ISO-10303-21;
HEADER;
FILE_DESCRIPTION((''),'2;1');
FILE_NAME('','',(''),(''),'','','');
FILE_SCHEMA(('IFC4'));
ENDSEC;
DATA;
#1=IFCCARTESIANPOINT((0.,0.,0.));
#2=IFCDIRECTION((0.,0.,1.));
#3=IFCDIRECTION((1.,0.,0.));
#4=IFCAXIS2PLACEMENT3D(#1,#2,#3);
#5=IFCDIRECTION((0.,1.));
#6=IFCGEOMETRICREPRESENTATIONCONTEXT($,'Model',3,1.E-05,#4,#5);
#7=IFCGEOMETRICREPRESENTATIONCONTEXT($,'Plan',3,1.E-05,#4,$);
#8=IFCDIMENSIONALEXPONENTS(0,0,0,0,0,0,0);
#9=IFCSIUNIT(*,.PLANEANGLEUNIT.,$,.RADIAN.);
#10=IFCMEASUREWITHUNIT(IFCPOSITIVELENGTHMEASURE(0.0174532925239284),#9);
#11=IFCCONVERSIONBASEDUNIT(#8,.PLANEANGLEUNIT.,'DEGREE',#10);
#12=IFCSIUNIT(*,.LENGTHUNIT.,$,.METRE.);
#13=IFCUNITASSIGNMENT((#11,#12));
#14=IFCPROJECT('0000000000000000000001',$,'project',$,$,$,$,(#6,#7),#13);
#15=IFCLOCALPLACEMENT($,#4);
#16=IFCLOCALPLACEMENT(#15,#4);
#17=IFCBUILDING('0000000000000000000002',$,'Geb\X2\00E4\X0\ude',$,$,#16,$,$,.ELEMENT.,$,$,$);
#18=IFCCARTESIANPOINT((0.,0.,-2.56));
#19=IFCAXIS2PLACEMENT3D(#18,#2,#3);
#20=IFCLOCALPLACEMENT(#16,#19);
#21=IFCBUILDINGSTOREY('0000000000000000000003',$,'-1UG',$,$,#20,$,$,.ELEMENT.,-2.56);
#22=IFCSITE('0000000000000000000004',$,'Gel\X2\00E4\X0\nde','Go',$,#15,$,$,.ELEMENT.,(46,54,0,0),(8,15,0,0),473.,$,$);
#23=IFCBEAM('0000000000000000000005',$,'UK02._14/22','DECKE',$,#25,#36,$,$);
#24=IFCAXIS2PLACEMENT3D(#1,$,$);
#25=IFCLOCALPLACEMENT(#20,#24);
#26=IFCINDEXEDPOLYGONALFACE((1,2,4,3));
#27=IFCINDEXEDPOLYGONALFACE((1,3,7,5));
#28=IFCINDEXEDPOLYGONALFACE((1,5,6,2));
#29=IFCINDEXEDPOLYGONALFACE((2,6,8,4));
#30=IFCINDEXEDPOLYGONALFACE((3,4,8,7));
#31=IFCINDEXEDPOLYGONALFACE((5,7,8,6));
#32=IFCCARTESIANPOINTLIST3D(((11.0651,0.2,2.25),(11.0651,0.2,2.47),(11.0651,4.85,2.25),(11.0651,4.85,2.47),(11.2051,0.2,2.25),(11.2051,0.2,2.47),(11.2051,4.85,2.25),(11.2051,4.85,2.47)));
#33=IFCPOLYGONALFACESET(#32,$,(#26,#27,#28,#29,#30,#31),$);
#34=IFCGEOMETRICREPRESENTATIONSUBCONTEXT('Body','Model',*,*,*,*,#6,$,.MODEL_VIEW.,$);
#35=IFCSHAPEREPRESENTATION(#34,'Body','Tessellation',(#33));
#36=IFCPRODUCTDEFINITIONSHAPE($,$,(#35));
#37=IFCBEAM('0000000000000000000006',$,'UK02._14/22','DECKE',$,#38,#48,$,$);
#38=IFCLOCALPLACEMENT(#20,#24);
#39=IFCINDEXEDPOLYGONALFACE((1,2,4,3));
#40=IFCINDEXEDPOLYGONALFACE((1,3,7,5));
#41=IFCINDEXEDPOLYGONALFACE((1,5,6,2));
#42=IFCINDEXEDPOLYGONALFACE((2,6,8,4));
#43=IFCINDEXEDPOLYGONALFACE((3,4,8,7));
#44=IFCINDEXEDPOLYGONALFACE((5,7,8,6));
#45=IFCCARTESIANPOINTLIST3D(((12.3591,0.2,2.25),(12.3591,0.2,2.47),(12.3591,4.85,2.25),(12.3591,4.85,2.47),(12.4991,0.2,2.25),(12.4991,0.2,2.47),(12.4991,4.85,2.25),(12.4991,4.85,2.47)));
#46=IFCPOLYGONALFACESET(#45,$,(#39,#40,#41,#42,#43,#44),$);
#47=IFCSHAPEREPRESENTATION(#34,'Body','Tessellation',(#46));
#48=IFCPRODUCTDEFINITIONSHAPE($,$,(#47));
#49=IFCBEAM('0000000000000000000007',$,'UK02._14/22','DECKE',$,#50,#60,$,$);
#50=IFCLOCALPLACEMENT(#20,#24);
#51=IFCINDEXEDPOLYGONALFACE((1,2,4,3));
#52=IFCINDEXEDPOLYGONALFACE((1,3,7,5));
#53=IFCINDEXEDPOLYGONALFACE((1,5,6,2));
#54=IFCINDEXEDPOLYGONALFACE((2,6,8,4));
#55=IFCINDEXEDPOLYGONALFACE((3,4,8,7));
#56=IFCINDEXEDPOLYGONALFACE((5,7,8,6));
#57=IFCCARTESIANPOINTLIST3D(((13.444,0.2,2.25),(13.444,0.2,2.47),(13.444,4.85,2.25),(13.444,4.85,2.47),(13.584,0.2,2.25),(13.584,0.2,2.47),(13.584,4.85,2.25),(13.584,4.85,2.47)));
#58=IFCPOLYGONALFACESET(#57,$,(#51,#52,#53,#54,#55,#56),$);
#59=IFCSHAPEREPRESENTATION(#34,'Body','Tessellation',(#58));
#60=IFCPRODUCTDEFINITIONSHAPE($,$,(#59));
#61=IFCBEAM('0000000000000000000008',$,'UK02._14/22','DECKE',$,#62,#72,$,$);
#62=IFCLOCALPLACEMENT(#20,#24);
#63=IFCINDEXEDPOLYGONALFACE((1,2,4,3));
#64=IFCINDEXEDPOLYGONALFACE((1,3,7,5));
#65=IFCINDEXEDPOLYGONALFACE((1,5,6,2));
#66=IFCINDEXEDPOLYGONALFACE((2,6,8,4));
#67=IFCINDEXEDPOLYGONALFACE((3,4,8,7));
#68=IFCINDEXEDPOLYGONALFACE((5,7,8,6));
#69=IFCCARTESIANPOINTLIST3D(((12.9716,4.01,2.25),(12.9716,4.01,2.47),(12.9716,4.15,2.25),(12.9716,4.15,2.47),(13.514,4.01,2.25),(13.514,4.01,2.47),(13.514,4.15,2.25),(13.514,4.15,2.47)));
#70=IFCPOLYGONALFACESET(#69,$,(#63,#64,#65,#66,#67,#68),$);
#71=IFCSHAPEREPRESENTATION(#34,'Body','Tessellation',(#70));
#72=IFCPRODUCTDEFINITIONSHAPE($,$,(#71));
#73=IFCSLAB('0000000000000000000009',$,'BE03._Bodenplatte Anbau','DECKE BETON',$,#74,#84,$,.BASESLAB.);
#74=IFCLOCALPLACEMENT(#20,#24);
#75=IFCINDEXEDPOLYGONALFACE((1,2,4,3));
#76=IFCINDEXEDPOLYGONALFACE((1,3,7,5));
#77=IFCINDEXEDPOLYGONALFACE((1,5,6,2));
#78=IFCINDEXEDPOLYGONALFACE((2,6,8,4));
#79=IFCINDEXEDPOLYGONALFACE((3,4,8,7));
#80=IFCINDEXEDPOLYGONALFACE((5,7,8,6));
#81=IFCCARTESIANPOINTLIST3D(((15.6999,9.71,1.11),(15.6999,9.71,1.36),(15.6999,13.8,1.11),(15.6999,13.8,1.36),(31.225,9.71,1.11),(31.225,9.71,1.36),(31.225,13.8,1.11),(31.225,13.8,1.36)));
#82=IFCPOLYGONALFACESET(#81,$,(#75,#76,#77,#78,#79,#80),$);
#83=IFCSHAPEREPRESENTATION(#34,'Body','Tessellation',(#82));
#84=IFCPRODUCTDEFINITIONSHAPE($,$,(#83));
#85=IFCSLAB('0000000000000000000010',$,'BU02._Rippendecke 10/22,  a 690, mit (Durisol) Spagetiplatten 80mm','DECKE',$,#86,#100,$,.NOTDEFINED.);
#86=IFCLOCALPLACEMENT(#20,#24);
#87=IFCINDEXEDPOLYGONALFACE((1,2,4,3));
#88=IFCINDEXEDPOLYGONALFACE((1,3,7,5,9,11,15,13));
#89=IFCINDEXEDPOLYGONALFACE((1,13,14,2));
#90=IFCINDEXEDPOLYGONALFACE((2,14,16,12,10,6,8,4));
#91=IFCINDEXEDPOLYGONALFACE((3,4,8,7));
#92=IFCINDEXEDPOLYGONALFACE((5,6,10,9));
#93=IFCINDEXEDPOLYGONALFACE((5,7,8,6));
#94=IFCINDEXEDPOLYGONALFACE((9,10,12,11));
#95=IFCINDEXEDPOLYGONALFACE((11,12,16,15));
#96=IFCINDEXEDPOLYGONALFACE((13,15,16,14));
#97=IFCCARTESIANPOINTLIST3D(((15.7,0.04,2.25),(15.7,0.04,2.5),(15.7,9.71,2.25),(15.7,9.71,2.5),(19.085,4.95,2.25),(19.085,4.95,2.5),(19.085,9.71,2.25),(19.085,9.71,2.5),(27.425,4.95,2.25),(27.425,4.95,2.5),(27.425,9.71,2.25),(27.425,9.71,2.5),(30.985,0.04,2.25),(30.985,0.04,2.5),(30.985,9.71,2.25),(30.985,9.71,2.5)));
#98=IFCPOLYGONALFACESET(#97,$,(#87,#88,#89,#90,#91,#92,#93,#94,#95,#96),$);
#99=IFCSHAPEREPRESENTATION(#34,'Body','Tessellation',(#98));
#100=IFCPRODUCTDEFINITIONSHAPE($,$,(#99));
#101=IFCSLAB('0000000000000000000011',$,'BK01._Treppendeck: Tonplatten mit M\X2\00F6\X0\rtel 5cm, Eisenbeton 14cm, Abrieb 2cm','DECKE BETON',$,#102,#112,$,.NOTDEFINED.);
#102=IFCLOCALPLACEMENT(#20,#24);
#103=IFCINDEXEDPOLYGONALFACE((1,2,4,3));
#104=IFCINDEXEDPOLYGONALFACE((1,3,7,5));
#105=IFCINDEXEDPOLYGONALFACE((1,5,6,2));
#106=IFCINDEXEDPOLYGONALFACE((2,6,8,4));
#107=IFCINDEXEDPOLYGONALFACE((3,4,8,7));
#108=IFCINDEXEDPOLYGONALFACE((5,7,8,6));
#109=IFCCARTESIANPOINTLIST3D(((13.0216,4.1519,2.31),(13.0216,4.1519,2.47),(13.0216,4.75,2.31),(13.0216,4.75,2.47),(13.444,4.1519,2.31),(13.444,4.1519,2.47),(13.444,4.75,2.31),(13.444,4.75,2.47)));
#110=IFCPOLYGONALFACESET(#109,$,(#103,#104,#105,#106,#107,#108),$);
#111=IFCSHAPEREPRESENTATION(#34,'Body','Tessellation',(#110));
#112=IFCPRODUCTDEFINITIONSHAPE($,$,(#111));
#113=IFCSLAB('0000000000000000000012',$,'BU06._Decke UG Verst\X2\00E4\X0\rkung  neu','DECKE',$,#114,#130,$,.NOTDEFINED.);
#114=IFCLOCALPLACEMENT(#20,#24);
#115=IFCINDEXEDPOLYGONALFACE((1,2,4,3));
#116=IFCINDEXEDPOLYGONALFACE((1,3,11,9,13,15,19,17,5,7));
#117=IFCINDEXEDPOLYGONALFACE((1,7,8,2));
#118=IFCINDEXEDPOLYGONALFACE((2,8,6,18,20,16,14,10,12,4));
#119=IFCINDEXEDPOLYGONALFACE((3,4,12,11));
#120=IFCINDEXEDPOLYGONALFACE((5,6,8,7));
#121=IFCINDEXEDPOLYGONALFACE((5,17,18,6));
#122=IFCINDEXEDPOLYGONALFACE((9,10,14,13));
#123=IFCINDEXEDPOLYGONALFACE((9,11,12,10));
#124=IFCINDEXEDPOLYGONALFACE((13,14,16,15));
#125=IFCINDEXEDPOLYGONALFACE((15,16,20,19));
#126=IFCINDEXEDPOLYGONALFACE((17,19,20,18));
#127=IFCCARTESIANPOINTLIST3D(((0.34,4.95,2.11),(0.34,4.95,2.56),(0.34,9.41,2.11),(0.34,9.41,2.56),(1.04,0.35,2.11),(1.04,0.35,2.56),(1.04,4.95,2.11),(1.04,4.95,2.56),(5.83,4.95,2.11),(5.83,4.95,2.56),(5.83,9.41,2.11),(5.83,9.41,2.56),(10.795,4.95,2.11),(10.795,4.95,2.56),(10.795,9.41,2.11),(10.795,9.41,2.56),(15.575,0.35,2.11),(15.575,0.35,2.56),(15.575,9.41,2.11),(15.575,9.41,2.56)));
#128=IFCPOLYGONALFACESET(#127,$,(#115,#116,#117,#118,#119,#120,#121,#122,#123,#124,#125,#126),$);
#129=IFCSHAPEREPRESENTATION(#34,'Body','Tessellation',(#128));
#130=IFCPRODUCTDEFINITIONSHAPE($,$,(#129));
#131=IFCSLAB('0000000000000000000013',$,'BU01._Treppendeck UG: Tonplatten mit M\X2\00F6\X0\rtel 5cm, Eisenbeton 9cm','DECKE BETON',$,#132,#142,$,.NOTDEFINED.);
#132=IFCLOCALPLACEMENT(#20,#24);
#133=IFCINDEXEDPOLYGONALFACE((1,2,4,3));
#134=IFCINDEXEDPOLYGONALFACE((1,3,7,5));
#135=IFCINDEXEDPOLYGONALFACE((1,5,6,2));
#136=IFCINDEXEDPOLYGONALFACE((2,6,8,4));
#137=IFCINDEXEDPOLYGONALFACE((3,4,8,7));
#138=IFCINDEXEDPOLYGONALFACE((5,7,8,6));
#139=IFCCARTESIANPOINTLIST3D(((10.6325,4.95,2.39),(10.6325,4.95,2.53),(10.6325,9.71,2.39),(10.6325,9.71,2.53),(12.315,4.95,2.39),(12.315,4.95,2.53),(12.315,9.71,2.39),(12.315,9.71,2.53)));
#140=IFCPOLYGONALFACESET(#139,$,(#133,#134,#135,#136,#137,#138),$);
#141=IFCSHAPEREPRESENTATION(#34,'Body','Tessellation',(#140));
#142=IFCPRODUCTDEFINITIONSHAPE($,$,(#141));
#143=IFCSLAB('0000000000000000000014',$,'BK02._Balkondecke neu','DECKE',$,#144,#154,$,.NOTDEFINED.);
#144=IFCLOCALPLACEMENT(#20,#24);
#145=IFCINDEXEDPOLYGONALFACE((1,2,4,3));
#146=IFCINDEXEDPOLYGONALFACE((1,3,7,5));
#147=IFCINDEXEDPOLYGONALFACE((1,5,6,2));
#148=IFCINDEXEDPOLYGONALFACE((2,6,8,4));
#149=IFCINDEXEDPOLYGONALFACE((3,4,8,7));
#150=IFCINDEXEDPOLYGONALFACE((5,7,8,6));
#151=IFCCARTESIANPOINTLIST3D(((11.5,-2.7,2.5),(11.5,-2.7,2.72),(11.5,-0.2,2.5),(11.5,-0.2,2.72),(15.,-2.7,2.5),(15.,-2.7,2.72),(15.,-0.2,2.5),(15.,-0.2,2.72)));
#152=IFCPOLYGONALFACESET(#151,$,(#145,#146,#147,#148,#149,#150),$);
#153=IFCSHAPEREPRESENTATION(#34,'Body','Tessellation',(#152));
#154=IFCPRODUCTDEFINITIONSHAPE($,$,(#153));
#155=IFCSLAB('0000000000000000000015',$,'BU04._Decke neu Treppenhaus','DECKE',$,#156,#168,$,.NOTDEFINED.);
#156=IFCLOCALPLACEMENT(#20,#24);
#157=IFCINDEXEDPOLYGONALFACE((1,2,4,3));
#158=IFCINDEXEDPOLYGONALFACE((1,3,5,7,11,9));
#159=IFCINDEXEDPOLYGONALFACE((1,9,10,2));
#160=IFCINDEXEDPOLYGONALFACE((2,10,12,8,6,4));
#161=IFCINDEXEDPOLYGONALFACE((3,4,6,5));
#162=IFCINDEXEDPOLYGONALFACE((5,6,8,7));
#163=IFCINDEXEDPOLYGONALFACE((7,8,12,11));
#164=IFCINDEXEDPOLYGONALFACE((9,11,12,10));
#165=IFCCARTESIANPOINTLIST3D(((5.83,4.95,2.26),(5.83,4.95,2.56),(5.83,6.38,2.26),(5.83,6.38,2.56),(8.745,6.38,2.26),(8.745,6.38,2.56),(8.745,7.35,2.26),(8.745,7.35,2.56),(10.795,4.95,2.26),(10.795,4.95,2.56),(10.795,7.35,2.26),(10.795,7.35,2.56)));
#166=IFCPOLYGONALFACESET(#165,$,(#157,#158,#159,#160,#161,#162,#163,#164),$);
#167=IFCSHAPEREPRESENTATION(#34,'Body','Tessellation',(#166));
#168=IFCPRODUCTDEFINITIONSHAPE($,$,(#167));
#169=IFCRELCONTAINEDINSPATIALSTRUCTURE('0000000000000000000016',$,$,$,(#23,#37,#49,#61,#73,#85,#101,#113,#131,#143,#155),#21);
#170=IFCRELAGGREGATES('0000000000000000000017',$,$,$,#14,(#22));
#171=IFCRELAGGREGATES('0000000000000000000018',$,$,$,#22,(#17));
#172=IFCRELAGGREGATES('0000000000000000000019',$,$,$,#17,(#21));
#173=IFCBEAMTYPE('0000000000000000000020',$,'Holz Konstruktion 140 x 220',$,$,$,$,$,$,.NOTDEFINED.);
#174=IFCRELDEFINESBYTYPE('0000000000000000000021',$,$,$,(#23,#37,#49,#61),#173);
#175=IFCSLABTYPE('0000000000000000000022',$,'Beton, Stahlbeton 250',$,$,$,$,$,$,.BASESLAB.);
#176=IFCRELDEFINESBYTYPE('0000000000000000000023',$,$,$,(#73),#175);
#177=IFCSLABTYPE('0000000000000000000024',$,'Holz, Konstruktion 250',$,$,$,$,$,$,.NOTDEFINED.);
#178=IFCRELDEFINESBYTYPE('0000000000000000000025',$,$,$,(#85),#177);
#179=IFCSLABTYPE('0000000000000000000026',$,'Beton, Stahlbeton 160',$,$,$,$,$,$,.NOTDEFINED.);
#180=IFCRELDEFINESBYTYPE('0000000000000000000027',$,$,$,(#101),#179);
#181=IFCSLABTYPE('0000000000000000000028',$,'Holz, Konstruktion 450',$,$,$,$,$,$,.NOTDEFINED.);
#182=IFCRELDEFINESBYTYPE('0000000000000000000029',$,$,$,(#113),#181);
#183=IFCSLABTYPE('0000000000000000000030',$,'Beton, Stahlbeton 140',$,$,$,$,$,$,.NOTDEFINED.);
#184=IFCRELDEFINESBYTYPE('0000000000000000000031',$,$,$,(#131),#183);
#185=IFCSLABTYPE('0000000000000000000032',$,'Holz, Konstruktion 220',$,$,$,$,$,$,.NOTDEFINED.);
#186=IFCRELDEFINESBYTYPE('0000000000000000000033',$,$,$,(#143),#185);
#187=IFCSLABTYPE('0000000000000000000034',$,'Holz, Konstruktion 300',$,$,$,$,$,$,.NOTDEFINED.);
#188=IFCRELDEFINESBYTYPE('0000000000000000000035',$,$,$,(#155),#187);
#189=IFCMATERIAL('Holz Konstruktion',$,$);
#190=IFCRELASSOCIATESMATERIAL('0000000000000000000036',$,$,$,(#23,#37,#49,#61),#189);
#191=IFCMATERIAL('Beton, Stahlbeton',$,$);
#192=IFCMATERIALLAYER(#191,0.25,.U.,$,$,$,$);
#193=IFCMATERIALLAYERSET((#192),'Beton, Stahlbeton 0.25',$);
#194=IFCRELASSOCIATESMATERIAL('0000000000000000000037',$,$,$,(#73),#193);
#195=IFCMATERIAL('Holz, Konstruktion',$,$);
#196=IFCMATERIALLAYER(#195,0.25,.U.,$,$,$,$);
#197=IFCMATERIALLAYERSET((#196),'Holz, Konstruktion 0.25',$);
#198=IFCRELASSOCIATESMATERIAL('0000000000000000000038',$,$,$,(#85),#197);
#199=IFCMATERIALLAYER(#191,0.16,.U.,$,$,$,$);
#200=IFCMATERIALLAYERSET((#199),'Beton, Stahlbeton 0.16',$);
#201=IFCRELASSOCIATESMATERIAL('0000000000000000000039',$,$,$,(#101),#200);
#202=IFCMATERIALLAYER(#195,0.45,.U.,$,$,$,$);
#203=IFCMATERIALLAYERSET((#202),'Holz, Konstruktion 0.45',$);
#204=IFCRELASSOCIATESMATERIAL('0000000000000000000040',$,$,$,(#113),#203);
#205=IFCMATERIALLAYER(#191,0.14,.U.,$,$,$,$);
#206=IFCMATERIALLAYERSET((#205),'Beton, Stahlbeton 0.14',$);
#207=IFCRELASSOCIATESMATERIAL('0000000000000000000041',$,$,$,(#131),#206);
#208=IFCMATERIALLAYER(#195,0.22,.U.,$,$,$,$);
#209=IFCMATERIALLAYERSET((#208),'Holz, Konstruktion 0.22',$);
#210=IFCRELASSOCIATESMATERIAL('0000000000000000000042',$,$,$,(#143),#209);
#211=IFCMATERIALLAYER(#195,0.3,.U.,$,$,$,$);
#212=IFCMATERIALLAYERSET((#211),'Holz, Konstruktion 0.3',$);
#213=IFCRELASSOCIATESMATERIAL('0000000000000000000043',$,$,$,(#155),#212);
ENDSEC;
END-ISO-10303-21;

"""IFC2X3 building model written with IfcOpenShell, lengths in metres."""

from ifc_helpers import new_model, entity, si_unit, converted_unit, direction, frame, frame_2d, origin_with_axes, place, context, subcontext, project, spatial, polyline, rectangle, outline, extrude, material, layer, layer_set, layer_usage, type_object, element, save


model = new_model("IFC2X3")

# Units and contexts
model_context = context("Model", 3, precision=1e-05, world=origin_with_axes(), true_north=direction((0.0, 1.0)))
plan_context = context("Plan", 3, precision=1e-05, world=origin_with_axes())
body_context = subcontext(model_context, "Body", "Model", "MODEL_VIEW")
ifc_project = project(units=[converted_unit("PLANEANGLEUNIT", "DEGREE", entity("IfcPositiveLengthMeasure", 0.0174532925239284), si_unit("PLANEANGLEUNIT", "RADIAN"), dimensions=[0, 0, 0, 0, 0, 0, 0]), si_unit("LENGTHUNIT", "METRE")], contexts=[model_context, plan_context])

# Site, building, storey
site_placement = place(None, origin_with_axes())
site = spatial("IfcSite", under=ifc_project, at=site_placement, Name="Gelände", Description="Go", CompositionType="ELEMENT", RefLatitude=(46, 54, 0, 0), RefLongitude=(8, 15, 0, 0), RefElevation=473.0)
building_placement = place(site_placement, origin_with_axes())
building = spatial("IfcBuilding", under=site, at=building_placement, Name="Gebäude", CompositionType="ELEMENT")
storey_placement = place(building_placement, frame((0.0, 0.0, -2.56), z_axis=(0.0, 0.0, 1.0), x_axis=(1.0, 0.0, 0.0)))
storey = spatial("IfcBuildingStorey", under=building, at=storey_placement, Name="-1UG", CompositionType="ELEMENT", Elevation=-2.56)

# Shared definitions
ifc_material_1 = material(Name="Beton, Stahlbeton")

# Beams
ifc_material_2 = material(Name="Holz Konstruktion")
beam_type_1 = type_object("IfcBeamType", Name="Holz Konstruktion 140 x 220", PredefinedType="NOTDEFINED")
for number, where, z_axis, x_axis, name in (
    (1, (11.1351, 0.2, 2.47), (0.0, 0.0, 1.0), (1.0, 0.0, 0.0), "UK02._14/22"),
    (2, (12.4291, 0.2, 2.47), (0.0, 0.0, 1.0), (1.0, 0.0, 0.0), "UK02._14/22"),
    (3, (13.514, 0.2, 2.47), (0.0, 0.0, 1.0), (1.0, 0.0, 0.0), "UK02._14/22"),
):
    element("IfcBeam", number, at=place(storey_placement, frame(where, z_axis=z_axis, x_axis=x_axis)), inside=storey, type_object=beam_type_1, material=ifc_material_2, Name=name, Description="DECKE", context=body_context, shape_type="SweptSolid", body=[
        extrude(rectangle(XDim=0.22, YDim=0.14, at=frame_2d((-0.11, 0.0), x_axis=(1.0, 0.0))), frame((0.0, 0.0, 0.0), z_axis=(0.0, 1.0, 0.0), x_axis=(0.0, 0.0, 1.0)), (0.0, 0.0, 1.0), 4.65),
    ])
beam_1_placement = place(storey_placement, frame((13.514, 4.08, 2.47), z_axis=(0.0, 0.0, 1.0), x_axis=(0.0, 1.0, 0.0)))
element("IfcBeam", 4, at=beam_1_placement, inside=storey, type_object=beam_type_1, material=ifc_material_2, Name="UK02._14/22", Description="DECKE", context=body_context, shape_type="SweptSolid", body=[
    extrude(rectangle(XDim=0.22, YDim=0.14, at=frame_2d((-0.11, 0.0), x_axis=(1.0, 0.0))), frame((0.0, 0.0, 0.0), z_axis=(0.0, 1.0, 0.0), x_axis=(0.0, 0.0, 1.0)), (0.0, 0.0, 1.0), 0.5424),
])

# Slabs
ifc_layer_1 = layer(ifc_material_1, 0.25, ventilated="UNKNOWN")
ifc_layer_set_1 = layer_set([ifc_layer_1], Name="Beton, Stahlbeton 0.25")
ifc_layer_usage_1 = layer_usage(ifc_layer_set_1, "AXIS3", "NEGATIVE", 0.25)
slab_type_1 = type_object("IfcSlabType", Name="Beton, Stahlbeton 250", PredefinedType="BASESLAB")
slab_1_placement = place(storey_placement, frame((15.6999, 9.71, 1.36), z_axis=(0.0, 0.0, 1.0), x_axis=(1.0, 0.0, 0.0)))
element("IfcSlab", 5, at=slab_1_placement, inside=storey, type_object=slab_type_1, material=ifc_layer_usage_1, Name="BE03._Bodenplatte Anbau", Description="DECKE BETON", PredefinedType="BASESLAB", context=body_context, shape_type="SweptSolid", body=[
    extrude(outline(polyline([(0.0, 0.0), (15.5251, 0.0), (15.5251, 4.09), (0.0, 4.09), (0.0, 0.0)])), frame((0.0, 0.0, -0.25), z_axis=(0.0, 0.0, 1.0), x_axis=(1.0, 0.0, 0.0)), (0.0, 0.0, 1.0), 0.25),
])
ifc_material_3 = material(Name="Holz, Konstruktion")
ifc_layer_2 = layer(ifc_material_3, 0.25, ventilated="UNKNOWN")
ifc_layer_set_2 = layer_set([ifc_layer_2], Name="Holz, Konstruktion 0.25")
ifc_layer_usage_2 = layer_usage(ifc_layer_set_2, "AXIS3", "NEGATIVE", 0.25)
slab_type_2 = type_object("IfcSlabType", Name="Holz, Konstruktion 250", PredefinedType="NOTDEFINED")
slab_2_placement = place(storey_placement, frame((15.7, 0.04, 2.5), z_axis=(0.0, 0.0, 1.0), x_axis=(1.0, 0.0, 0.0)))
element("IfcSlab", 6, at=slab_2_placement, inside=storey, type_object=slab_type_2, material=ifc_layer_usage_2, Name="BU02._Rippendecke 10/22,  a 690, mit (Durisol) Spagetiplatten 80mm", Description="DECKE", PredefinedType="NOTDEFINED", context=body_context, shape_type="SweptSolid", body=[
    extrude(outline(polyline([(0.0, 0.0), (15.285, 0.0), (15.285, 9.67), (11.725, 9.67), (11.725, 4.91), (3.385, 4.91), (3.385, 9.67), (0.0, 9.67), (0.0, 0.0)])), frame((0.0, 0.0, -0.25), z_axis=(0.0, 0.0, 1.0), x_axis=(1.0, 0.0, 0.0)), (0.0, 0.0, 1.0), 0.25),
])
ifc_layer_3 = layer(ifc_material_1, 0.16, ventilated="UNKNOWN")
ifc_layer_set_3 = layer_set([ifc_layer_3], Name="Beton, Stahlbeton 0.16")
ifc_layer_usage_3 = layer_usage(ifc_layer_set_3, "AXIS3", "NEGATIVE", 0.16)
slab_type_3 = type_object("IfcSlabType", Name="Beton, Stahlbeton 160", PredefinedType="NOTDEFINED")
slab_3_placement = place(storey_placement, frame((13.0216, 4.1519, 2.47), z_axis=(0.0, 0.0, 1.0), x_axis=(1.0, 0.0, 0.0)))
element("IfcSlab", 7, at=slab_3_placement, inside=storey, type_object=slab_type_3, material=ifc_layer_usage_3, Name="BK01._Treppendeck: Tonplatten mit Mörtel 5cm, Eisenbeton 14cm, Abrieb 2cm", Description="DECKE BETON", PredefinedType="NOTDEFINED", context=body_context, shape_type="SweptSolid", body=[
    extrude(outline(polyline([(0.0, 0.0), (0.4224, 0.0), (0.4224, 0.5981), (0.0, 0.5981), (0.0, 0.0)])), frame((0.0, 0.0, -0.16), z_axis=(0.0, 0.0, 1.0), x_axis=(1.0, 0.0, 0.0)), (0.0, 0.0, 1.0), 0.16),
])
ifc_layer_4 = layer(ifc_material_3, 0.45, ventilated="UNKNOWN")
ifc_layer_set_4 = layer_set([ifc_layer_4], Name="Holz, Konstruktion 0.45")
ifc_layer_usage_4 = layer_usage(ifc_layer_set_4, "AXIS3", "NEGATIVE", 0.45)
slab_type_4 = type_object("IfcSlabType", Name="Holz, Konstruktion 450", PredefinedType="NOTDEFINED")
slab_4_placement = place(storey_placement, frame((15.575, 0.35, 2.56), z_axis=(0.0, 0.0, 1.0), x_axis=(1.0, 0.0, 0.0)))
element("IfcSlab", 8, at=slab_4_placement, inside=storey, type_object=slab_type_4, material=ifc_layer_usage_4, Name="BU06._Decke UG Verstärkung  neu", Description="DECKE", PredefinedType="NOTDEFINED", context=body_context, shape_type="SweptSolid", body=[
    extrude(outline(polyline([(0.0, 0.0), (0.0, 9.06), (-4.78, 9.06), (-4.78, 4.6), (-9.745, 4.6), (-9.745, 9.06), (-15.235, 9.06), (-15.235, 4.6), (-14.535, 4.6), (-14.535, 0.0), (0.0, 0.0)])), frame((0.0, 0.0, -0.45), z_axis=(0.0, 0.0, 1.0), x_axis=(1.0, 0.0, 0.0)), (0.0, 0.0, 1.0), 0.45),
])
ifc_layer_5 = layer(ifc_material_1, 0.14, ventilated="UNKNOWN")
ifc_layer_set_5 = layer_set([ifc_layer_5], Name="Beton, Stahlbeton 0.14")
ifc_layer_usage_5 = layer_usage(ifc_layer_set_5, "AXIS3", "NEGATIVE", 0.14)
slab_type_5 = type_object("IfcSlabType", Name="Beton, Stahlbeton 140", PredefinedType="NOTDEFINED")
slab_5_placement = place(storey_placement, frame((12.315, 4.95, 2.53), z_axis=(0.0, 0.0, 1.0), x_axis=(1.0, 0.0, 0.0)))
element("IfcSlab", 9, at=slab_5_placement, inside=storey, type_object=slab_type_5, material=ifc_layer_usage_5, Name="BU01._Treppendeck UG: Tonplatten mit Mörtel 5cm, Eisenbeton 9cm", Description="DECKE BETON", PredefinedType="NOTDEFINED", context=body_context, shape_type="SweptSolid", body=[
    extrude(outline(polyline([(0.0, 0.0), (0.0, 4.76), (-1.6825, 4.76), (-1.6825, 0.0), (0.0, 0.0)])), frame((0.0, 0.0, -0.14), z_axis=(0.0, 0.0, 1.0), x_axis=(1.0, 0.0, 0.0)), (0.0, 0.0, 1.0), 0.14),
])
ifc_layer_6 = layer(ifc_material_3, 0.22, ventilated="UNKNOWN")
ifc_layer_set_6 = layer_set([ifc_layer_6], Name="Holz, Konstruktion 0.22")
ifc_layer_usage_6 = layer_usage(ifc_layer_set_6, "AXIS3", "NEGATIVE", 0.22)
slab_type_6 = type_object("IfcSlabType", Name="Holz, Konstruktion 220", PredefinedType="NOTDEFINED")
slab_6_placement = place(storey_placement, frame((11.5, -2.7, 2.72), z_axis=(0.0, 0.0, 1.0), x_axis=(1.0, 0.0, 0.0)))
element("IfcSlab", 10, at=slab_6_placement, inside=storey, type_object=slab_type_6, material=ifc_layer_usage_6, Name="BK02._Balkondecke neu", Description="DECKE", PredefinedType="NOTDEFINED", context=body_context, shape_type="SweptSolid", body=[
    extrude(outline(polyline([(0.0, 0.0), (3.5, 0.0), (3.5, 2.5), (0.0, 2.5), (0.0, 0.0)])), frame((0.0, 0.0, -0.22), z_axis=(0.0, 0.0, 1.0), x_axis=(1.0, 0.0, 0.0)), (0.0, 0.0, 1.0), 0.22),
])
ifc_layer_7 = layer(ifc_material_3, 0.3, ventilated="UNKNOWN")
ifc_layer_set_7 = layer_set([ifc_layer_7], Name="Holz, Konstruktion 0.3")
ifc_layer_usage_7 = layer_usage(ifc_layer_set_7, "AXIS3", "NEGATIVE", 0.3)
slab_type_7 = type_object("IfcSlabType", Name="Holz, Konstruktion 300", PredefinedType="NOTDEFINED")
slab_7_placement = place(storey_placement, frame((10.795, 7.35, 2.56), z_axis=(0.0, 0.0, 1.0), x_axis=(1.0, 0.0, 0.0)))
element("IfcSlab", 11, at=slab_7_placement, inside=storey, type_object=slab_type_7, material=ifc_layer_usage_7, Name="BU04._Decke neu Treppenhaus", Description="DECKE", PredefinedType="NOTDEFINED", context=body_context, shape_type="SweptSolid", body=[
    extrude(outline(polyline([(0.0, 0.0), (-2.05, 0.0), (-2.05, -0.97), (-4.965, -0.97), (-4.965, -2.4), (0.0, -2.4), (0.0, 0.0)])), frame((0.0, 0.0, -0.3), z_axis=(0.0, 0.0, 1.0), x_axis=(1.0, 0.0, 0.0)), (0.0, 0.0, 1.0), 0.3),
])

save(model, "model.ifc")
